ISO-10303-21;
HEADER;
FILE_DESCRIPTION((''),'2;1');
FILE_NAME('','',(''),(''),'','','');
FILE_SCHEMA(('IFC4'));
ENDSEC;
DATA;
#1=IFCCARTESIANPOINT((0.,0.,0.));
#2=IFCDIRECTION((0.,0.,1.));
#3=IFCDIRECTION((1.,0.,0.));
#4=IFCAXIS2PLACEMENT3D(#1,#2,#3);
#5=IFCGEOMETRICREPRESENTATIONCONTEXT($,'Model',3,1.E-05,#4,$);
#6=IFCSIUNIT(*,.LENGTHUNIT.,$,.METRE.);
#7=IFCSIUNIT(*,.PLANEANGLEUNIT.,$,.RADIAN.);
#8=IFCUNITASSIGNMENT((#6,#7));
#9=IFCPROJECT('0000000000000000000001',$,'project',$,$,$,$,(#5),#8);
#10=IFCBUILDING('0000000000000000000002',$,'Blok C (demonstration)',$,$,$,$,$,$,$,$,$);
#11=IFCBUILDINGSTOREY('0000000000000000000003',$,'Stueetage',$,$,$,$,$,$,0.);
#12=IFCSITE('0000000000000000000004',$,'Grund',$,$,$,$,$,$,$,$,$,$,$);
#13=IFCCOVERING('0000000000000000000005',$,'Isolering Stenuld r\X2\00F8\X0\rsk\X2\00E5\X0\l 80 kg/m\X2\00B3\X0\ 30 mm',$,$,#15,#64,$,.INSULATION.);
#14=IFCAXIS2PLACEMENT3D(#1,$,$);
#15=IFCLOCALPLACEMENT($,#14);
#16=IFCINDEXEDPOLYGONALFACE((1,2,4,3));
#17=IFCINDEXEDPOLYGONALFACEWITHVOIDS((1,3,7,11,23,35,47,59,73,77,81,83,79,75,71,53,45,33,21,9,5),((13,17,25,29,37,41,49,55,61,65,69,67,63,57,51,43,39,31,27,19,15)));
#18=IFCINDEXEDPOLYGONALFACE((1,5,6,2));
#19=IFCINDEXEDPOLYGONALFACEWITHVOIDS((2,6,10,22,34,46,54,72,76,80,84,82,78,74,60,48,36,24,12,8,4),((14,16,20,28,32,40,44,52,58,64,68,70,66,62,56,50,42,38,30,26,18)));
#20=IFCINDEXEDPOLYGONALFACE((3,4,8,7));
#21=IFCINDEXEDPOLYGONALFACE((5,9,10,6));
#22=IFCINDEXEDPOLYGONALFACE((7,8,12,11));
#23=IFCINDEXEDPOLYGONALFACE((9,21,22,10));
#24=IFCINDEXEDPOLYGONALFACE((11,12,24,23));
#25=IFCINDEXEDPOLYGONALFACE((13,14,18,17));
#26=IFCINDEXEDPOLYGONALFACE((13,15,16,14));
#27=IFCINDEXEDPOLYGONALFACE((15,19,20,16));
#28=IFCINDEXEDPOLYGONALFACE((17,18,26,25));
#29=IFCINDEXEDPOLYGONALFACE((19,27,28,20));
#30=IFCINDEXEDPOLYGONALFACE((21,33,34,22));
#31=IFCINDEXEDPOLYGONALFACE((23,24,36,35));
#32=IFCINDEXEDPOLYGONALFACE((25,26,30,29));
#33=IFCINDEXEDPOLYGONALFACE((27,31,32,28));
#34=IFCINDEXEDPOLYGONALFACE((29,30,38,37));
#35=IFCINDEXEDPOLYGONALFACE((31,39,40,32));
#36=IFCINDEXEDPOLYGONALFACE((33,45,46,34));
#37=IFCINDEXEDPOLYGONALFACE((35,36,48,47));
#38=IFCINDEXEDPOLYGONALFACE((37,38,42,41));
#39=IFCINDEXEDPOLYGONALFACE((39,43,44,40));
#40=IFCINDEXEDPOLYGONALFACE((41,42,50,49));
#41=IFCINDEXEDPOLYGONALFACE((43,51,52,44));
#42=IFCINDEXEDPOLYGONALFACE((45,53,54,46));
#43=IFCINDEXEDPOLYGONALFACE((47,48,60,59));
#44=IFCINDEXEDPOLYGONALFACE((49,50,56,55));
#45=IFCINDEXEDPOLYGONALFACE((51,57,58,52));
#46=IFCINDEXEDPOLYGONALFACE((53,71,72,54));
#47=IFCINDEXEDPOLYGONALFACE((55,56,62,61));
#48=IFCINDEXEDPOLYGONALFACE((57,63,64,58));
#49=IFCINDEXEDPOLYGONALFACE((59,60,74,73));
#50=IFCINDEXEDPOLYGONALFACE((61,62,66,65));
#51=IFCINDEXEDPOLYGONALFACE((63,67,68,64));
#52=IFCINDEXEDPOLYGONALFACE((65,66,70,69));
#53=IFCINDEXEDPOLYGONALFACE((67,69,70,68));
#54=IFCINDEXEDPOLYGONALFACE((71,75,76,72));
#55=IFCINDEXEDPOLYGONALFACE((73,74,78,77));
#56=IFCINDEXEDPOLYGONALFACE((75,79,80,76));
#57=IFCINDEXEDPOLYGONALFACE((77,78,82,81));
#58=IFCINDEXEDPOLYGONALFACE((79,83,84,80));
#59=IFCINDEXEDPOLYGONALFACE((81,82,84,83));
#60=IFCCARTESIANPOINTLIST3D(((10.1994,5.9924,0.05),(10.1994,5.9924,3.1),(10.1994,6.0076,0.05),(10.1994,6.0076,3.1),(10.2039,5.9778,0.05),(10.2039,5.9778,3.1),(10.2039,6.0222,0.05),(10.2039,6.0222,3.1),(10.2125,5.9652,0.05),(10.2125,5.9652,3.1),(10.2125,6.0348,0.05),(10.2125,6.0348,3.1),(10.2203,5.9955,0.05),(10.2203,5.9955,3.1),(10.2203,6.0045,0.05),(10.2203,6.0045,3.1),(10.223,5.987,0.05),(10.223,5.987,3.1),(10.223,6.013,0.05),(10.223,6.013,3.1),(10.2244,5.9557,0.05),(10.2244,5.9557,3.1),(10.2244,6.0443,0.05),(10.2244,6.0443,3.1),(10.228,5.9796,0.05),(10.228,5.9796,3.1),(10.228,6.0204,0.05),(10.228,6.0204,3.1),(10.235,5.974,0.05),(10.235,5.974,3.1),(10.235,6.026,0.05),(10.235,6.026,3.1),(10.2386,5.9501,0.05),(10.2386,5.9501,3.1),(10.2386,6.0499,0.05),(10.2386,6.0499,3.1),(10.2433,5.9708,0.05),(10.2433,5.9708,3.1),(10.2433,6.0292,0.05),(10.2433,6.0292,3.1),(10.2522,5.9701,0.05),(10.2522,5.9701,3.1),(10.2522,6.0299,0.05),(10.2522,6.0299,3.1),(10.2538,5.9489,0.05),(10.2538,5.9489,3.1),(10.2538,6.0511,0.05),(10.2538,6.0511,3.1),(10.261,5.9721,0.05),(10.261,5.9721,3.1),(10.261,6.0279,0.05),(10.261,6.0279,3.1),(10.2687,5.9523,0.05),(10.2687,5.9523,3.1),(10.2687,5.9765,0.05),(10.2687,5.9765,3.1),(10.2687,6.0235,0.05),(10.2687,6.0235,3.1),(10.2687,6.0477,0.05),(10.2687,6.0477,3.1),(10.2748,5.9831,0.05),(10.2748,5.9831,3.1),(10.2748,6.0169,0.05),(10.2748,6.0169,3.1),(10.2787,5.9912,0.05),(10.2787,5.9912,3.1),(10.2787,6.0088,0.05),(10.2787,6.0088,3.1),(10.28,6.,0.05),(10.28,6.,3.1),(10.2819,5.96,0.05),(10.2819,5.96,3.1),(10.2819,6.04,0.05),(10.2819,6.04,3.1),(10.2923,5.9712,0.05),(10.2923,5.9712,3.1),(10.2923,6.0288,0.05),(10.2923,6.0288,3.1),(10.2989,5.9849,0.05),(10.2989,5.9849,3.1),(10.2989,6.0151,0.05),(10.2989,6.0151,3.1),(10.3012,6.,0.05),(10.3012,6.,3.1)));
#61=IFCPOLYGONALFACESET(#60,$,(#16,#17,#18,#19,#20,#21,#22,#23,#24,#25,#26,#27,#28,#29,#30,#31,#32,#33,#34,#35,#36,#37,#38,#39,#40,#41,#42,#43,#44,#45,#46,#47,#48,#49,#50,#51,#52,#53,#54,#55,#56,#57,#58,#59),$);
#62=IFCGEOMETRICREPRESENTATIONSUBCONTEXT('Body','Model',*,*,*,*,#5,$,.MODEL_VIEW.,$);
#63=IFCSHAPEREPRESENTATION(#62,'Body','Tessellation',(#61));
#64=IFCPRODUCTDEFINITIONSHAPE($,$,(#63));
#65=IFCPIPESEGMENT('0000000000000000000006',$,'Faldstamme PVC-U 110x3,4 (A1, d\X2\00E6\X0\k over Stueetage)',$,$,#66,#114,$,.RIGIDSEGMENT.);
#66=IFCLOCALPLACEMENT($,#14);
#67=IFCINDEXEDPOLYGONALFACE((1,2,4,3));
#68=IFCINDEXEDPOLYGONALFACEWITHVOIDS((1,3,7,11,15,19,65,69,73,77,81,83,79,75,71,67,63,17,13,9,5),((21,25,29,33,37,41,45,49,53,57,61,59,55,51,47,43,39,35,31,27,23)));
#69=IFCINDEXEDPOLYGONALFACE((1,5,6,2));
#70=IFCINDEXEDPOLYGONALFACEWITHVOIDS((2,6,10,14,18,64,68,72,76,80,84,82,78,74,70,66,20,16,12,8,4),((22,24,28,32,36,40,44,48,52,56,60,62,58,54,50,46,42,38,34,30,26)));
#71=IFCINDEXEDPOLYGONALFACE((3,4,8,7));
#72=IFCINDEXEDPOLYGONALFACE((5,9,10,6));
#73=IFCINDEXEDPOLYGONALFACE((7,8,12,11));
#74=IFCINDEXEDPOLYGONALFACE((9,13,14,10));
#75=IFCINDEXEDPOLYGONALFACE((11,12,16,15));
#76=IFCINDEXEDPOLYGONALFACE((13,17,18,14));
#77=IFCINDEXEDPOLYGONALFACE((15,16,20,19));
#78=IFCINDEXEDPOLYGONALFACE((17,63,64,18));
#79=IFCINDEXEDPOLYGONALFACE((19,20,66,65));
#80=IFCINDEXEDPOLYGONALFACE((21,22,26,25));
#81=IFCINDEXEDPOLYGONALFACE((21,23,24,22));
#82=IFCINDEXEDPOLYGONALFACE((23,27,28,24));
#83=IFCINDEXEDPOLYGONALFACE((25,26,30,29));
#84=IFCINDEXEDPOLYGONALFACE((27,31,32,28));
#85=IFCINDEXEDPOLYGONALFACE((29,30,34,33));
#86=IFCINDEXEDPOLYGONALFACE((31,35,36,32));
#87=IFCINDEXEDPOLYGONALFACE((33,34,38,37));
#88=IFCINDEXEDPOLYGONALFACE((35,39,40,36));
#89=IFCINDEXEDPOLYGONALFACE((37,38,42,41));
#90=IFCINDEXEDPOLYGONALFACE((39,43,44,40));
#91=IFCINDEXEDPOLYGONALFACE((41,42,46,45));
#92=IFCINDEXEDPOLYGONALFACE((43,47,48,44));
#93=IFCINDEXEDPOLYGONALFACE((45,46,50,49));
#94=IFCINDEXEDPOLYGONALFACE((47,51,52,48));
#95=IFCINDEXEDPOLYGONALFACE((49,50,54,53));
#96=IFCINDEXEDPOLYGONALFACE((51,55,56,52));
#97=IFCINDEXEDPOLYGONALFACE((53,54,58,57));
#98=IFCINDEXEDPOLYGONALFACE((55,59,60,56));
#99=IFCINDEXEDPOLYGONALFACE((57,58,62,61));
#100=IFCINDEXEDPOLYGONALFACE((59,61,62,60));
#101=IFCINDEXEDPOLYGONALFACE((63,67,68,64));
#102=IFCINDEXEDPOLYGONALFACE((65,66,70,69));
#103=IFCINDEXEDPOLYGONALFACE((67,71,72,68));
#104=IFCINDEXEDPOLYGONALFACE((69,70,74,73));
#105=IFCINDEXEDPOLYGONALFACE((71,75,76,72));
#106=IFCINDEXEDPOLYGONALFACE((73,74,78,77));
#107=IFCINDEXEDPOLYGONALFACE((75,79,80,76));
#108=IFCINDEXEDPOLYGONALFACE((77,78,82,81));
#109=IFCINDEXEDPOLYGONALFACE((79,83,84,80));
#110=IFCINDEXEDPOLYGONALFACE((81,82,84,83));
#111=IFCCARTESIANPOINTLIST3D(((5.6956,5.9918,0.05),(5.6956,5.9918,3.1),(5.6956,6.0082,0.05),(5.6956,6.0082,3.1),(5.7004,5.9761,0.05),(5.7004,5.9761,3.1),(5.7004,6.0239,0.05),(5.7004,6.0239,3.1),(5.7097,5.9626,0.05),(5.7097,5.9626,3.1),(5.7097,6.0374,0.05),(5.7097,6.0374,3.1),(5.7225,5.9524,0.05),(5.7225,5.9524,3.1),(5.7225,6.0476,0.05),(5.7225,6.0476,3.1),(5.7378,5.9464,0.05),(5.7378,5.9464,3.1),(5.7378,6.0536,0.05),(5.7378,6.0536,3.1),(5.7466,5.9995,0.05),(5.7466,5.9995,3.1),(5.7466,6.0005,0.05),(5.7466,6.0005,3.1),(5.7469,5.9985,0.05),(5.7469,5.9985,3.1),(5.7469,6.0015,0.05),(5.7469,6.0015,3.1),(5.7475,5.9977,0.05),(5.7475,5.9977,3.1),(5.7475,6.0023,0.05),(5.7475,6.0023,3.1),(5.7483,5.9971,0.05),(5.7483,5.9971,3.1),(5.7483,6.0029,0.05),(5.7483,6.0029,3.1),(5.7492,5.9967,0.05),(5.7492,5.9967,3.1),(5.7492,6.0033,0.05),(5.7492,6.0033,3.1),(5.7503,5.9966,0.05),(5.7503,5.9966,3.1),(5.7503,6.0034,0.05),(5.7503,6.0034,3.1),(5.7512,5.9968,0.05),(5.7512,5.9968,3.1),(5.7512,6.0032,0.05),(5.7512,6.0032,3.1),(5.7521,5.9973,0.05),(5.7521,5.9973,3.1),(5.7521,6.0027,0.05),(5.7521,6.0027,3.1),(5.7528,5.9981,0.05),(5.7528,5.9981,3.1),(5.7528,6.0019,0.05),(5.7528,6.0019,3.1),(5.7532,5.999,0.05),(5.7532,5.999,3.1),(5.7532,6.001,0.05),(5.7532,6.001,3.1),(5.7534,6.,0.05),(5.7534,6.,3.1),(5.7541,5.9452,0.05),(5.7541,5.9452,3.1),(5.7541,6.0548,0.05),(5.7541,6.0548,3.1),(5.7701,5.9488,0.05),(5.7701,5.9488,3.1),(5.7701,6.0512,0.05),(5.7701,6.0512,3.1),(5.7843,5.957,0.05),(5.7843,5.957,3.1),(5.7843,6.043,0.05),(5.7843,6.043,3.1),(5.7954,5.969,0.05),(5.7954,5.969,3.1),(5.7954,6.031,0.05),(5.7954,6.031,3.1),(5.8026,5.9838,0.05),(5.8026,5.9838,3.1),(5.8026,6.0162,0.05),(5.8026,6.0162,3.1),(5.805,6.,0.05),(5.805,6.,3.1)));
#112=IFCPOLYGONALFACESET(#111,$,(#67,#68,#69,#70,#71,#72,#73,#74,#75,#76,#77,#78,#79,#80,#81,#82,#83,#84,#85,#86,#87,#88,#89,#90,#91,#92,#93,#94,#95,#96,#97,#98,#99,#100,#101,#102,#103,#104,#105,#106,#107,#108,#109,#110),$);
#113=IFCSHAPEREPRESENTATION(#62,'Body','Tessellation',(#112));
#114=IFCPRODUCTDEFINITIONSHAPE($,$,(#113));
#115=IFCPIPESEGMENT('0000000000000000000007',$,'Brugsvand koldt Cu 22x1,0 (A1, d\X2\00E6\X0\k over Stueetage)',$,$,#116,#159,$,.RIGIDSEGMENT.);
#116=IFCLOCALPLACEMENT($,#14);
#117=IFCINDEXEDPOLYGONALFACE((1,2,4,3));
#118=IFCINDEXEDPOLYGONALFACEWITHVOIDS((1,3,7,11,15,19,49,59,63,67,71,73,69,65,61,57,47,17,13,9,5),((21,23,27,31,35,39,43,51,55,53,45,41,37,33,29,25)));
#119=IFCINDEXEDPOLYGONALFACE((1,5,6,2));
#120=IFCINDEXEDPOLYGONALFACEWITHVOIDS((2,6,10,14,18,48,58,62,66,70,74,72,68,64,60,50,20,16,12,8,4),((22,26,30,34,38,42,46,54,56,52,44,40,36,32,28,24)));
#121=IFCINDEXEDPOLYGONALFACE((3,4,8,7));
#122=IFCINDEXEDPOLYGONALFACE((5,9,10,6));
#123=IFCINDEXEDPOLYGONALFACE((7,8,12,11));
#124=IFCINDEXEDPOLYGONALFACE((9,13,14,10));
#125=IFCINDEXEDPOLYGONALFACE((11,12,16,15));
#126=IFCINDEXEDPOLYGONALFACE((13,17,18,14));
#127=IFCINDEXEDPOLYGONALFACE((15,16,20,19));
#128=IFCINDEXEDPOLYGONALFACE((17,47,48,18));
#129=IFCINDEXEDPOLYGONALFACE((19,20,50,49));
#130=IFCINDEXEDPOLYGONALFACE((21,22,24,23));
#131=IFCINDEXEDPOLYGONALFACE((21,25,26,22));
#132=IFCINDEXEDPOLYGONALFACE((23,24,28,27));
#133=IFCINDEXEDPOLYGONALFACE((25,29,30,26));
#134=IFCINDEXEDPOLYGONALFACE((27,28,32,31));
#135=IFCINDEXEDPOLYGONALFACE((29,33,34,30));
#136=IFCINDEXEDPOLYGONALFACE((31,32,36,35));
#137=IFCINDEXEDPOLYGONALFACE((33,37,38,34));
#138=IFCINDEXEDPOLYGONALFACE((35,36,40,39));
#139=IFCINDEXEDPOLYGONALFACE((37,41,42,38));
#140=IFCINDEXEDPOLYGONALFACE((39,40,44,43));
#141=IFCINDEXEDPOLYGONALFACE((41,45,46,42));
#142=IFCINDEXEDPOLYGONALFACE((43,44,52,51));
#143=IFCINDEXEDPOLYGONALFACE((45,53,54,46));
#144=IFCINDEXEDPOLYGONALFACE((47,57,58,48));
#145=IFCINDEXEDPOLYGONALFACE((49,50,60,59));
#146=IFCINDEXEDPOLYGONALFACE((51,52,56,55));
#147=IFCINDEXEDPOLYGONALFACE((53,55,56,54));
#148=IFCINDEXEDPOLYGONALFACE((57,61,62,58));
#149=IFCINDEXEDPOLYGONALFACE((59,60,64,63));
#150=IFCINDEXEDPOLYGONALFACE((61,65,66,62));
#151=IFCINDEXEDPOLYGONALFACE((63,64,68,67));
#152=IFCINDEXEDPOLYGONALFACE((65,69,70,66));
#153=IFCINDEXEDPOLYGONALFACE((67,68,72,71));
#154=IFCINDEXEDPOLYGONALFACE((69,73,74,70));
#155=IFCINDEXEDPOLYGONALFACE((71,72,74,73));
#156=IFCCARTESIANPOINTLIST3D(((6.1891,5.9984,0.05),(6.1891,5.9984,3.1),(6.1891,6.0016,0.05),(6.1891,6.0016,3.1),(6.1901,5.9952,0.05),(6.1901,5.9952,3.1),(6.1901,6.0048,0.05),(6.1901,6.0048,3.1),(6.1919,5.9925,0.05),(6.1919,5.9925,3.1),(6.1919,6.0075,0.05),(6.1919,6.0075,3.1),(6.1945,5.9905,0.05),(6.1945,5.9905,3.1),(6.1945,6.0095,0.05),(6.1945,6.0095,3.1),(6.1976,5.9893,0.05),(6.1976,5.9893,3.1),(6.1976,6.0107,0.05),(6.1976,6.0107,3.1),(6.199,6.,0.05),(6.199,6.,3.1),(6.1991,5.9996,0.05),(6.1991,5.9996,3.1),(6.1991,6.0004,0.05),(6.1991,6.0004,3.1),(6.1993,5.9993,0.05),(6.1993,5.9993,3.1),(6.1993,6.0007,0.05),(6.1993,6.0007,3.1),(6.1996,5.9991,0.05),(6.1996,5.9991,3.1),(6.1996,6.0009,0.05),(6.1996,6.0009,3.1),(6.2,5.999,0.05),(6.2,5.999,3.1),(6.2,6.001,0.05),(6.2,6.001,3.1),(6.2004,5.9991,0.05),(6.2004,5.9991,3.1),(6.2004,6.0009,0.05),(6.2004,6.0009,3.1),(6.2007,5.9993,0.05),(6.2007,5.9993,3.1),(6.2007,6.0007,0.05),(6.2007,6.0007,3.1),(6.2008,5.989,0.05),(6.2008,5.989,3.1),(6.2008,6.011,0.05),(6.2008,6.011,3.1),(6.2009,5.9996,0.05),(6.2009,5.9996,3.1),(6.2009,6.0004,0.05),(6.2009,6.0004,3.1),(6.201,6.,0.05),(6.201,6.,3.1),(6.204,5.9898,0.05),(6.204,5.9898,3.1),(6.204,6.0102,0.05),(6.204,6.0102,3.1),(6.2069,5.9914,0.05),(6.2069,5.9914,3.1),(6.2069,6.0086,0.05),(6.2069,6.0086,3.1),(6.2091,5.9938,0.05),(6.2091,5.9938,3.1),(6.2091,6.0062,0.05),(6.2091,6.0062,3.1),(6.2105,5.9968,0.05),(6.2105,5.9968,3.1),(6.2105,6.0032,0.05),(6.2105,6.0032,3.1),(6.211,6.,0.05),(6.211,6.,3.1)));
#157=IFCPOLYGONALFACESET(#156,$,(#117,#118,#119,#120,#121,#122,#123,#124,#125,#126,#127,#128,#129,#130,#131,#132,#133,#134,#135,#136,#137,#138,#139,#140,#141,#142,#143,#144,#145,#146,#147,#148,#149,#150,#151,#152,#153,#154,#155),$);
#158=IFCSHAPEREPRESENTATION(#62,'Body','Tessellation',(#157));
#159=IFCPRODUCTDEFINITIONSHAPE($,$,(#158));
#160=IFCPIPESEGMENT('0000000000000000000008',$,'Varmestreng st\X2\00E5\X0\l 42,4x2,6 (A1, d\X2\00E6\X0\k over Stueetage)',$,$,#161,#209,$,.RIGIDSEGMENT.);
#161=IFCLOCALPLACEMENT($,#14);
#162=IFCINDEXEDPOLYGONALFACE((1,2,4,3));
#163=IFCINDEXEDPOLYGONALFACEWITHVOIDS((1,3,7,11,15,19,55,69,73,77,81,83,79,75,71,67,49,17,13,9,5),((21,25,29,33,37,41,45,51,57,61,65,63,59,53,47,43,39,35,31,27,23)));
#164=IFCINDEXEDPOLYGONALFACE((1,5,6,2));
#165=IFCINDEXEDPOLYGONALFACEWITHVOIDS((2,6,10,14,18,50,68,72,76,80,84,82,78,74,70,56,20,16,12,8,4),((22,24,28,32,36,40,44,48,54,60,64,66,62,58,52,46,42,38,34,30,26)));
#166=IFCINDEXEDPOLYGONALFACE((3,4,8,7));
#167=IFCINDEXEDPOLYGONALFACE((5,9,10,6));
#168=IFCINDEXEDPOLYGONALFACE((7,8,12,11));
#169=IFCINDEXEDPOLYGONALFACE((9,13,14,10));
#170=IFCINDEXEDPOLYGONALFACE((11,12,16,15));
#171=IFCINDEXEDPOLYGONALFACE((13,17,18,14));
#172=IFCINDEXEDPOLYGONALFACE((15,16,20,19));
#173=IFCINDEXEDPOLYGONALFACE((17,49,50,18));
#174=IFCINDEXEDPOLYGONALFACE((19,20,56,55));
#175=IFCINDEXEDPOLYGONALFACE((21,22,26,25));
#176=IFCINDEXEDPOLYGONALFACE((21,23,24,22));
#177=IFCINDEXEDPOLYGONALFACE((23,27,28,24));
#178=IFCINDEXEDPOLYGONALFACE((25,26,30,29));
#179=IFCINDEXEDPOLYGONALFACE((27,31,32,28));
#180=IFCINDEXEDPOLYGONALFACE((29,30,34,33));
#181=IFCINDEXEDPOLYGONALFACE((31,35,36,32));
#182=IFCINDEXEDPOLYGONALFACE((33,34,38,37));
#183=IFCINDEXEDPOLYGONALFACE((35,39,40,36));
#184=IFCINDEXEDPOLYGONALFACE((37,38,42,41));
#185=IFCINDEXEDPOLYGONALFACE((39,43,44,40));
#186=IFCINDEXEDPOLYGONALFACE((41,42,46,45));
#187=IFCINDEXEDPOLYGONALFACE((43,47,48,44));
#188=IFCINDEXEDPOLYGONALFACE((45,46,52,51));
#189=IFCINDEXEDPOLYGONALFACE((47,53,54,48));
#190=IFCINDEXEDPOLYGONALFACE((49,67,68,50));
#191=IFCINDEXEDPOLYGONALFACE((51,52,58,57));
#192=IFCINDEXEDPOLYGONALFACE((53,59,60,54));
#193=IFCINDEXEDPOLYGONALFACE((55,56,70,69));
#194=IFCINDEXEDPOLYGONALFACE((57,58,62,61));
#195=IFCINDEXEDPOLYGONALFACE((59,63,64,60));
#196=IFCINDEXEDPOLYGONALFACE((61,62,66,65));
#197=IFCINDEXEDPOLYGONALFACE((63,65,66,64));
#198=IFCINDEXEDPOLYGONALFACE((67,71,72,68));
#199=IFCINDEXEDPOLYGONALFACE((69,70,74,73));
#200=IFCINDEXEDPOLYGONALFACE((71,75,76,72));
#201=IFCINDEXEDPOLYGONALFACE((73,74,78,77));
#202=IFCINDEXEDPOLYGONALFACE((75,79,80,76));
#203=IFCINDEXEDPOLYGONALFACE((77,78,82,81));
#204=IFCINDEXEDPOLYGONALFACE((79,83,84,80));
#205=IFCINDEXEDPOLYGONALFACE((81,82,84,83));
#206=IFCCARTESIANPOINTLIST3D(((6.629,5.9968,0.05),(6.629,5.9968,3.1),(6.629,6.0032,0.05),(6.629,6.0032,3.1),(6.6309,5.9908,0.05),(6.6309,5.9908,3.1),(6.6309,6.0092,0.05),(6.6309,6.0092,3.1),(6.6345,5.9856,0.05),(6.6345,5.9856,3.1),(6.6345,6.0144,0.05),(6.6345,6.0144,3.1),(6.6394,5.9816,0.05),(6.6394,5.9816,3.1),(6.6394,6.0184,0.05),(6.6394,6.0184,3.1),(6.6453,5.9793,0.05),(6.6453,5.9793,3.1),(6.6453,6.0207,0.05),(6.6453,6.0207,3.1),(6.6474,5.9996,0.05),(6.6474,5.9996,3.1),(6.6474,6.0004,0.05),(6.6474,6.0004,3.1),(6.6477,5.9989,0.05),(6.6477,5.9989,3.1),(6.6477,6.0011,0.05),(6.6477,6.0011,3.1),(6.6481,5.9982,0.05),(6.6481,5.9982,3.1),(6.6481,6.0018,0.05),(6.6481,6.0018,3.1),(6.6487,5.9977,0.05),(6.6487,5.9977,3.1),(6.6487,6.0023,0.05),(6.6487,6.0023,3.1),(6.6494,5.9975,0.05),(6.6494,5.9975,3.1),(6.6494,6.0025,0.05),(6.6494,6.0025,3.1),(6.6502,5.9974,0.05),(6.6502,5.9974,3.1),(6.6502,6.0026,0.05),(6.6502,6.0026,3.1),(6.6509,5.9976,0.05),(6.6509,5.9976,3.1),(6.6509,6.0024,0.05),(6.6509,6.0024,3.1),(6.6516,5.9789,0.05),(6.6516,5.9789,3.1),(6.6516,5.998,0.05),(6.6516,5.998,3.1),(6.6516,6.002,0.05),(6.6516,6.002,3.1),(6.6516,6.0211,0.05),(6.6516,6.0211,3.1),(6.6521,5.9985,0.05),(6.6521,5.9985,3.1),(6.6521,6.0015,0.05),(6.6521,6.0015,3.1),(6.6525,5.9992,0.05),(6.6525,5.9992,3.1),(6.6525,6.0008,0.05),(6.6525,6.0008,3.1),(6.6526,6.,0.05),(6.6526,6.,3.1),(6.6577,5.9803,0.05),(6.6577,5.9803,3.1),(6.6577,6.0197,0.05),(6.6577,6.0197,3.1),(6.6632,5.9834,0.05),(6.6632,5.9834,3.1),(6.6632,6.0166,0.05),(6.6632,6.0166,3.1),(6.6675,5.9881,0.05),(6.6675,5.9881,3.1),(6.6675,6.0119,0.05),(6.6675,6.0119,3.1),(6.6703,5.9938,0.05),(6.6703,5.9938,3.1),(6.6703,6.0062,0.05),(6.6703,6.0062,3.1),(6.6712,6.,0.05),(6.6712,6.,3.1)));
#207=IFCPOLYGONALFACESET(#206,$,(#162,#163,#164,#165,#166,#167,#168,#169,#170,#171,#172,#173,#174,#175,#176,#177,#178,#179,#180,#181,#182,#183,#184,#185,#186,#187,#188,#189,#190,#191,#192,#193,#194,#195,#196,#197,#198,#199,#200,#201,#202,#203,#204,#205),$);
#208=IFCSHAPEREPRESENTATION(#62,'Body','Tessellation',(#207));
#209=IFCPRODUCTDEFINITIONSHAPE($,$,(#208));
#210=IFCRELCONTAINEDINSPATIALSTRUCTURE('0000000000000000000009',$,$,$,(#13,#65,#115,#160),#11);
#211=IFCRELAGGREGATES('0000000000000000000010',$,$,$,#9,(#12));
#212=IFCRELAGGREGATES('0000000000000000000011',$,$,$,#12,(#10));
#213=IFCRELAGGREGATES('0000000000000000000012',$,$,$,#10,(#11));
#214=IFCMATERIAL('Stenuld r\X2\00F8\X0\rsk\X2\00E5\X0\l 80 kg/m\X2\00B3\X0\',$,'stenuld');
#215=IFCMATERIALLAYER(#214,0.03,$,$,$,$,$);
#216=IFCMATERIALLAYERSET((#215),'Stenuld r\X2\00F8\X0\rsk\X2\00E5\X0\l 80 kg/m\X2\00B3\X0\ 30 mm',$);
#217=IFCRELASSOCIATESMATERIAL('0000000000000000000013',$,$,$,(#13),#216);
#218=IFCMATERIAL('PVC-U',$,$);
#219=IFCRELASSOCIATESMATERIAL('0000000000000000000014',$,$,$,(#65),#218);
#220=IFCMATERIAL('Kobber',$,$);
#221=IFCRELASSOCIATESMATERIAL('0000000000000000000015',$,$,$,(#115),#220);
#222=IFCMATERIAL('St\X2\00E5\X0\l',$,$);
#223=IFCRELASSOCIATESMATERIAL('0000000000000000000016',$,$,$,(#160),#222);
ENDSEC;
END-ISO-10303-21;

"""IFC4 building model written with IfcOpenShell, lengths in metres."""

from ifc_helpers import new_model, si_unit, frame, origin_with_axes, place, context, subcontext, project, spatial, hollow_circle, extrude, material, layer, layer_set, element, save


model = new_model("IFC4")

# Units and contexts
model_context = context("Model", 3, precision=1e-05, world=origin_with_axes())
body_context = subcontext(model_context, "Body", "Model", "MODEL_VIEW")
ifc_project = project(units=[si_unit("LENGTHUNIT", "METRE"), si_unit("PLANEANGLEUNIT", "RADIAN")], contexts=[model_context])

# Site, building, storey
site = spatial("IfcSite", under=ifc_project, Name="Grund")
building = spatial("IfcBuilding", under=site, Name="Blok C (demonstration)")
storey = spatial("IfcBuildingStorey", under=building, Name="Stueetage", Elevation=0.0)

# Covering
ifc_material_1 = material(Name="Stenuld rørskål 80 kg/m³", Category="stenuld")
ifc_layer_1 = layer(ifc_material_1, 0.03)
ifc_layer_set_1 = layer_set([ifc_layer_1], Name="Stenuld rørskål 80 kg/m³ 30 mm")
covering_1_placement = place(None, origin_with_axes())
element("IfcCovering", 1, at=covering_1_placement, inside=storey, material=ifc_layer_set_1, Name="Isolering Stenuld rørskål 80 kg/m³ 30 mm", PredefinedType="INSULATION", context=body_context, shape_type="SweptSolid", body=[
    extrude(hollow_circle(Radius=0.0512, WallThickness=0.0212), frame((10.25, 6.0, 0.05), z_axis=(0.0, 0.0, 1.0), x_axis=(1.0, 0.0, 0.0)), (0.0, 0.0, 1.0), 3.05),
])

# Pipe segments
ifc_material_2 = material(Name="PVC-U")
pipe_segment_1_placement = place(None, origin_with_axes())
element("IfcPipeSegment", 2, at=pipe_segment_1_placement, inside=storey, material=ifc_material_2, Name="Faldstamme PVC-U 110x3,4 (A1, dæk over Stueetage)", PredefinedType="RIGIDSEGMENT", context=body_context, shape_type="SweptSolid", body=[
    extrude(hollow_circle(Radius=0.055, WallThickness=0.0516), frame((5.75, 6.0, 0.05), z_axis=(0.0, 0.0, 1.0), x_axis=(1.0, 0.0, 0.0)), (0.0, 0.0, 1.0), 3.05),
])
ifc_material_3 = material(Name="Kobber")
pipe_segment_2_placement = place(None, origin_with_axes())
element("IfcPipeSegment", 3, at=pipe_segment_2_placement, inside=storey, material=ifc_material_3, Name="Brugsvand koldt Cu 22x1,0 (A1, dæk over Stueetage)", PredefinedType="RIGIDSEGMENT", context=body_context, shape_type="SweptSolid", body=[
    extrude(hollow_circle(Radius=0.011, WallThickness=0.01), frame((6.2, 6.0, 0.05), z_axis=(0.0, 0.0, 1.0), x_axis=(1.0, 0.0, 0.0)), (0.0, 0.0, 1.0), 3.05),
])
ifc_material_4 = material(Name="Stål")
pipe_segment_3_placement = place(None, origin_with_axes())
element("IfcPipeSegment", 4, at=pipe_segment_3_placement, inside=storey, material=ifc_material_4, Name="Varmestreng stål 42,4x2,6 (A1, dæk over Stueetage)", PredefinedType="RIGIDSEGMENT", context=body_context, shape_type="SweptSolid", body=[
    extrude(hollow_circle(Radius=0.0212, WallThickness=0.0186), frame((6.65, 6.0, 0.05), z_axis=(0.0, 0.0, 1.0), x_axis=(1.0, 0.0, 0.0)), (0.0, 0.0, 1.0), 3.05),
])

save(model, "model.ifc")
